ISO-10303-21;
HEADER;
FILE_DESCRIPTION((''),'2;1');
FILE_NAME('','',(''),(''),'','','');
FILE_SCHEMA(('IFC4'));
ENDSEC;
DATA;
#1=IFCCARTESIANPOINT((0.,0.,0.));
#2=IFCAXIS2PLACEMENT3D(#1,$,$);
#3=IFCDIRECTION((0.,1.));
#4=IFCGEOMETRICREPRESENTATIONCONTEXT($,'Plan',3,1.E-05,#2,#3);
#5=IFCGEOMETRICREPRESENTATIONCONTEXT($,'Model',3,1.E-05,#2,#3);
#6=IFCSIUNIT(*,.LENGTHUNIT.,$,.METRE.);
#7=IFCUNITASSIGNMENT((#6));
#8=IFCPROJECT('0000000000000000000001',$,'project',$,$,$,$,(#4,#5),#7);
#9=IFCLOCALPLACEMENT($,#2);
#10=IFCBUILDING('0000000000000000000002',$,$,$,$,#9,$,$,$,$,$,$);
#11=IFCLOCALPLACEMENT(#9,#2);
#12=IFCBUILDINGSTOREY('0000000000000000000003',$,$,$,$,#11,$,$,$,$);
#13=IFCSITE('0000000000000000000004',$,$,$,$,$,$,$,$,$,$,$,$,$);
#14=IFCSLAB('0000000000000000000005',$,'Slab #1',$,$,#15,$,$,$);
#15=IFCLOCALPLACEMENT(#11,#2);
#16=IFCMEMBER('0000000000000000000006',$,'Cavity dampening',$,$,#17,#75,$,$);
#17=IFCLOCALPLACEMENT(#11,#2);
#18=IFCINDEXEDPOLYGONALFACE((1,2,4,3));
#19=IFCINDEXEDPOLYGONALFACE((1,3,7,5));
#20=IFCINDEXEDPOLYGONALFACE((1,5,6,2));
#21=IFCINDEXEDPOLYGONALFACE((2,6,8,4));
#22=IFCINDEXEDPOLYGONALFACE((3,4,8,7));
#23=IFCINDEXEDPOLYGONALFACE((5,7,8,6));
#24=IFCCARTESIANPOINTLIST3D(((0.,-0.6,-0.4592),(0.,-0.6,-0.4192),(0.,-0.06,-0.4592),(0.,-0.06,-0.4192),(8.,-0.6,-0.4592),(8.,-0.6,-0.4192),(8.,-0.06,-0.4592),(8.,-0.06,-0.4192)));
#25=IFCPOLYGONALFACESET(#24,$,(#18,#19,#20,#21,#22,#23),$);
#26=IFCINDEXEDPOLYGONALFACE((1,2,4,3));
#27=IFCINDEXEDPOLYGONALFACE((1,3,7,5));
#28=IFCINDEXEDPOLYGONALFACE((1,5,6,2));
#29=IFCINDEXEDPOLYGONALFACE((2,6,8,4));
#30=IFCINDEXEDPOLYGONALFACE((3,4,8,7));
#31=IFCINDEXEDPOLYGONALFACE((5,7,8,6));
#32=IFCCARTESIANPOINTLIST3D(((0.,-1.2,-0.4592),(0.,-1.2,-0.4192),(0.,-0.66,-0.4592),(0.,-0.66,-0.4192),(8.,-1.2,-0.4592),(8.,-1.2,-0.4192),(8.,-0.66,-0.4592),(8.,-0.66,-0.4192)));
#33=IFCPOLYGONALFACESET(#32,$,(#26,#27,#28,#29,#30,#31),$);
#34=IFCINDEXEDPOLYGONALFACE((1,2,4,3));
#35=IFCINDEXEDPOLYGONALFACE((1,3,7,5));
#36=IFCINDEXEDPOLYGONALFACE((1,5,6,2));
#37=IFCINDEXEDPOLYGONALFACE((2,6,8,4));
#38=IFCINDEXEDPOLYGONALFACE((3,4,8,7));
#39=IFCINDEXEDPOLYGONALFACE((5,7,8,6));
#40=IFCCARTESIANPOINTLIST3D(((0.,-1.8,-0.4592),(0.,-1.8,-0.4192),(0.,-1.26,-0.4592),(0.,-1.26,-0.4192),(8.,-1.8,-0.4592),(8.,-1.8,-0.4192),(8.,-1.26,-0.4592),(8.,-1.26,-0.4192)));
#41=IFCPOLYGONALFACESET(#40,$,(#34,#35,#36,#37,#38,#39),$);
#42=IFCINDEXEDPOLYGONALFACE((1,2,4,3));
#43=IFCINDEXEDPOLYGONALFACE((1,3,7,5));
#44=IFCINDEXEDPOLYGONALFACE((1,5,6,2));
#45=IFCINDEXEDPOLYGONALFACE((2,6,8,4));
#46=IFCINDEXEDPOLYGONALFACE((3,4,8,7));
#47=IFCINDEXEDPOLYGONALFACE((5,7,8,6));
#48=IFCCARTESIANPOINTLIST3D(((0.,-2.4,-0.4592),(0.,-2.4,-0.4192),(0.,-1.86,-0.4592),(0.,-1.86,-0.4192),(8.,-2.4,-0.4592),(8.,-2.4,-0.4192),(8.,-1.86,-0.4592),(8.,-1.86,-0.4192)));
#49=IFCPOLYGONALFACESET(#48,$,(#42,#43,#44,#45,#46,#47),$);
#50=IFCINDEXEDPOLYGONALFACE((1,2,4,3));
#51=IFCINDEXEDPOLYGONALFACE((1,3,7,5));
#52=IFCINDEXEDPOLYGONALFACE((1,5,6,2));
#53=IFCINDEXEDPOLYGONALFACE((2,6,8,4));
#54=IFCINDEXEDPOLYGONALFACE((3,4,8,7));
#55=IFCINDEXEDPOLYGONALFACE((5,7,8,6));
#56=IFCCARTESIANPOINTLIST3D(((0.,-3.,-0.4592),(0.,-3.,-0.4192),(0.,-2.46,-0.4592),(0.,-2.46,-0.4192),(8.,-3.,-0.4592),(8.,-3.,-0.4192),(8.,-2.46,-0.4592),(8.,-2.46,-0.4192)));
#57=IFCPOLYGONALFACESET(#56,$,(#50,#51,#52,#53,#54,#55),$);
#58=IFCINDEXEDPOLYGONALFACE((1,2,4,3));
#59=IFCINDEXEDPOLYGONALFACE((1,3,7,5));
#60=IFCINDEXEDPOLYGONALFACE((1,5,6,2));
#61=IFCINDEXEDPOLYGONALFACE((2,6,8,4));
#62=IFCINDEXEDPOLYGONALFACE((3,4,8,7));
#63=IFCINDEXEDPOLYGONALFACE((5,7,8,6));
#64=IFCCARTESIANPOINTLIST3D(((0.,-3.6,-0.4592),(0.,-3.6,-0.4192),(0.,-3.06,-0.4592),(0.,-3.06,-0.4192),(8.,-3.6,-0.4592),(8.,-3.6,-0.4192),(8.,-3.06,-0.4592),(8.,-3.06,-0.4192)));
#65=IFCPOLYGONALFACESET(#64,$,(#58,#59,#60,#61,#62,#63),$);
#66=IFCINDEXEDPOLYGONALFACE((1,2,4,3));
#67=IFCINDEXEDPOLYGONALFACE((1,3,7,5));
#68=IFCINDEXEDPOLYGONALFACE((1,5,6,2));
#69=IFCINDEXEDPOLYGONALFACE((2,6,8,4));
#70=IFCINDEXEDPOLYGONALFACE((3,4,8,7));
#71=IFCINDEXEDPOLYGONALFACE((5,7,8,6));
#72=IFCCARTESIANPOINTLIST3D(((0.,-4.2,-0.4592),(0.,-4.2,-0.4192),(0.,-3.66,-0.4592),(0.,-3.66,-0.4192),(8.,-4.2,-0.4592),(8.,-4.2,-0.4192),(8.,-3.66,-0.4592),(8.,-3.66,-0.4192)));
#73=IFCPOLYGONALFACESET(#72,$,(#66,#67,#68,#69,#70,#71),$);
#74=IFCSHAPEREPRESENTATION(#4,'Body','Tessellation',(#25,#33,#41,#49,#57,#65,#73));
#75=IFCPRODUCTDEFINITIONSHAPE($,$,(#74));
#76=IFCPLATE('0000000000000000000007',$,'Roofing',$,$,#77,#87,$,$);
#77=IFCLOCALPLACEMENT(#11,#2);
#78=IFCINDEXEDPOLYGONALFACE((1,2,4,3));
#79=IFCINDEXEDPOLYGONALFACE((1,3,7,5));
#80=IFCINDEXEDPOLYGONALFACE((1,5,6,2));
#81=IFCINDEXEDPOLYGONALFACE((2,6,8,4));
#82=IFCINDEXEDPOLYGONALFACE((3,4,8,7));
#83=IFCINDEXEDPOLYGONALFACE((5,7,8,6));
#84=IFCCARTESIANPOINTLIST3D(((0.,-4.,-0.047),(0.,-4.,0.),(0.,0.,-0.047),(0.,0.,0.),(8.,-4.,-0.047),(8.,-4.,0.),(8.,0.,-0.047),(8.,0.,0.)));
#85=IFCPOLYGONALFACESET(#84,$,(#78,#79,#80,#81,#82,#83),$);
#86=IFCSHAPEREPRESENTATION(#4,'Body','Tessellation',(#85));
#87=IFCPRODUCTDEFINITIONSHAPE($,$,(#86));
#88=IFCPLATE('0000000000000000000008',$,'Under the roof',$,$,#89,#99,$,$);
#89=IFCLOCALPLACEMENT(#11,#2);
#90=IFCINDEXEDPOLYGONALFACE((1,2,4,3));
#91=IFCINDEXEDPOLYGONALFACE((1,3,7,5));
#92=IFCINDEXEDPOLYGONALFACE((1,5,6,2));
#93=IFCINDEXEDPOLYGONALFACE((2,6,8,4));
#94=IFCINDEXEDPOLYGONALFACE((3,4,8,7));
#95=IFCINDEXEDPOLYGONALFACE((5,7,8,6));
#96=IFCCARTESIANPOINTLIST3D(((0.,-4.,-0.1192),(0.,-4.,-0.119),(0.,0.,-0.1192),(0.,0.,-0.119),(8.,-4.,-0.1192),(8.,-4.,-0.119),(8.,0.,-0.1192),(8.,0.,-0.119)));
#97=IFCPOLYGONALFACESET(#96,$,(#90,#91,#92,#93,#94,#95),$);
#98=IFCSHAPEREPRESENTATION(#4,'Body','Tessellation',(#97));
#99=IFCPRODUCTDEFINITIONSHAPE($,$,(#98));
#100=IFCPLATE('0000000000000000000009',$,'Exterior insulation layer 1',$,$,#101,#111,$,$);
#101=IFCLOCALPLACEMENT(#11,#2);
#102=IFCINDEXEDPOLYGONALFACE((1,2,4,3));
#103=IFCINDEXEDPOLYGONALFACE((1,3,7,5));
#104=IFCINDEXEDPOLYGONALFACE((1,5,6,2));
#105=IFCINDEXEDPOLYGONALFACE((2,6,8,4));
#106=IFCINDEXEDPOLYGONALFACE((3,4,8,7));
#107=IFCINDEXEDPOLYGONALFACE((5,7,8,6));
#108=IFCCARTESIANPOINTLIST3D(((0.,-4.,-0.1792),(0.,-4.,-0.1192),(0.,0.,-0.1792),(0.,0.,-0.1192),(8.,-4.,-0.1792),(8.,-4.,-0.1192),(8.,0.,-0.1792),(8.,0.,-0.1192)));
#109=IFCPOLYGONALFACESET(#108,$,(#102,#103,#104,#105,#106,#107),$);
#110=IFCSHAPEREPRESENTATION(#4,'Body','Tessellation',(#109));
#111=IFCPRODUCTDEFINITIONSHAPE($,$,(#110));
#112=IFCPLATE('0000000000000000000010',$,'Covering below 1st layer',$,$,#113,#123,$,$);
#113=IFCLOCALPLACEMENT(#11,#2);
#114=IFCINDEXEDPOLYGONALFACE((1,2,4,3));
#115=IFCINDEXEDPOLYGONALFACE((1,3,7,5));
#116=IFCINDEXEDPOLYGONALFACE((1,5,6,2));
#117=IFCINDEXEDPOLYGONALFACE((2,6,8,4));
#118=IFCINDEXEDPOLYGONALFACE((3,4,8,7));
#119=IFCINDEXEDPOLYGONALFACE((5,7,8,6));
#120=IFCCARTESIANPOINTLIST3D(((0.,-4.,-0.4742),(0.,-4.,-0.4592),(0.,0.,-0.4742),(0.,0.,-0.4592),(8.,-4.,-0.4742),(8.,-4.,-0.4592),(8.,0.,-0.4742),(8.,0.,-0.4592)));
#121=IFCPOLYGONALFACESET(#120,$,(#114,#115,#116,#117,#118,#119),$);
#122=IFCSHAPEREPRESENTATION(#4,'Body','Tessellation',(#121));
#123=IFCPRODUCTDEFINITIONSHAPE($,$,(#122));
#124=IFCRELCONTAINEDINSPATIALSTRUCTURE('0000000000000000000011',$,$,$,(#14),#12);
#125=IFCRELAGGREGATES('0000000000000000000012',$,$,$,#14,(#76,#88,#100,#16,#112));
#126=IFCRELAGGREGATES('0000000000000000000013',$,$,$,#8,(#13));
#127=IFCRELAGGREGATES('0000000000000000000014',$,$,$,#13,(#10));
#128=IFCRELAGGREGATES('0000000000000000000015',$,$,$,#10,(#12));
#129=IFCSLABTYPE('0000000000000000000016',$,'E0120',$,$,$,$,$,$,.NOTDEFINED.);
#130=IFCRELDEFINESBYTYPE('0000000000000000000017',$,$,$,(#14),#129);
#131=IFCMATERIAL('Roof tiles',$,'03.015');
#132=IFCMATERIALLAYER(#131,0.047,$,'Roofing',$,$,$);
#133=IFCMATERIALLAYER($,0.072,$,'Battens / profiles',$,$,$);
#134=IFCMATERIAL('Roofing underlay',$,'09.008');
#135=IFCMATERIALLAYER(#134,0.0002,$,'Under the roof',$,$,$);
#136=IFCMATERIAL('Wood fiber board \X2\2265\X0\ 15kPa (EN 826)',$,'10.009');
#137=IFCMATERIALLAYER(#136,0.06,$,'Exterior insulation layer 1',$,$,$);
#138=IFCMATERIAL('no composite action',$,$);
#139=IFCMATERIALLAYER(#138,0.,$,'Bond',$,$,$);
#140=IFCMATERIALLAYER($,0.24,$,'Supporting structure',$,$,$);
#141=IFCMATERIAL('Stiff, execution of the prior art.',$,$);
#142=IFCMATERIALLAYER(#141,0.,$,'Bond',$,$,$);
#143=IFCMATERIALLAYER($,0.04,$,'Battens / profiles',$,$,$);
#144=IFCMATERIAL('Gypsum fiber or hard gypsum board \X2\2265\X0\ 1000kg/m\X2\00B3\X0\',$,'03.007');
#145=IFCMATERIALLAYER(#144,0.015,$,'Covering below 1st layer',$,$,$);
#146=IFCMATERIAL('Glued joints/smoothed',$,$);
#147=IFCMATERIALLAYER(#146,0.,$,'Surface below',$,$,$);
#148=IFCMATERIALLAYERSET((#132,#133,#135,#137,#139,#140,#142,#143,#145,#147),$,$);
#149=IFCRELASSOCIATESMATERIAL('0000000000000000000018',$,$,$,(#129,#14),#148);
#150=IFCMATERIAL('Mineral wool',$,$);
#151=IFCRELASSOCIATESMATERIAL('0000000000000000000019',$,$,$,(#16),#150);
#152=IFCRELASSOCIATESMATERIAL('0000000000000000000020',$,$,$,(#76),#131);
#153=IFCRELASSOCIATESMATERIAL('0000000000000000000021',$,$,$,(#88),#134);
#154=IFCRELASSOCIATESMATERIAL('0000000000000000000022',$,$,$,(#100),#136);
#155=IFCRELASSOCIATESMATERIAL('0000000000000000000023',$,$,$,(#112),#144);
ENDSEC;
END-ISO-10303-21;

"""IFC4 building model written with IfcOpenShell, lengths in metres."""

from ifc_helpers import new_model, si_unit, direction, frame, frame_2d, origin, origin_with_axes, place, context, project, spatial, rectangle, extrude, material, layer, layer_set, type_object, element, aggregate, save


model = new_model("IFC4")

# Units and contexts
plan_context = context("Plan", 3, precision=1e-05, world=origin(), true_north=direction((0.0, 1.0)))
model_context = context("Model", 3, precision=1e-05, world=origin(), true_north=direction((0.0, 1.0)))
ifc_project = project(units=[si_unit("LENGTHUNIT", "METRE")], contexts=[plan_context, model_context])

# Site, building, storey
site = spatial("IfcSite", under=ifc_project)
building_placement = place(None, origin())
building = spatial("IfcBuilding", under=site, at=building_placement)
storey_placement = place(building_placement, origin())
storey = spatial("IfcBuildingStorey", under=building, at=storey_placement)

# Slab, member, plates
ifc_material_1 = material(Name="Roof tiles", Category="03.015")
ifc_layer_1 = layer(ifc_material_1, 0.047, Name="Roofing")
ifc_layer_2 = layer(None, 0.072, Name="Battens / profiles")
ifc_material_2 = material(Name="Roofing underlay", Category="09.008")
ifc_layer_3 = layer(ifc_material_2, 0.0002, Name="Under the roof")
ifc_material_3 = material(Name="Wood fiber board ≥ 15kPa (EN 826)", Category="10.009")
ifc_layer_4 = layer(ifc_material_3, 0.06, Name="Exterior insulation layer 1")
ifc_material_4 = material(Name="no composite action")
ifc_layer_5 = layer(ifc_material_4, 0.0, Name="Bond")
ifc_layer_6 = layer(None, 0.24, Name="Supporting structure")
ifc_material_5 = material(Name="Stiff, execution of the prior art.")
ifc_layer_7 = layer(ifc_material_5, 0.0, Name="Bond")
ifc_layer_8 = layer(None, 0.04, Name="Battens / profiles")
ifc_material_6 = material(Name="Gypsum fiber or hard gypsum board ≥ 1000kg/m³", Category="03.007")
ifc_layer_9 = layer(ifc_material_6, 0.015, Name="Covering below 1st layer")
ifc_material_7 = material(Name="Glued joints/smoothed")
ifc_layer_10 = layer(ifc_material_7, 0.0, Name="Surface below")
ifc_layer_set = layer_set([ifc_layer_1, ifc_layer_2, ifc_layer_3, ifc_layer_4, ifc_layer_5, ifc_layer_6, ifc_layer_7, ifc_layer_8, ifc_layer_9, ifc_layer_10])
slab_type = type_object("IfcSlabType", Name="E0120", PredefinedType="NOTDEFINED", material=ifc_layer_set)
slab_placement = place(None, frame((0.0, 0.0, 0.0), z_axis=(0.0, 0.0, -1.0), x_axis=(1.0, 0.0, 0.0)))
slab = element("IfcSlab", 1, at=slab_placement, inside=storey, type_object=slab_type, material=ifc_layer_set, Name="Slab #1")
ifc_material_8 = material(Name="Mineral wool")
member_1_placement = place(slab_placement, origin())
member_1 = element("IfcMember", 2, at=member_1_placement, material=ifc_material_8, Name="Cavity dampening", context=plan_context, shape_type="SweptSolid", body=[
    extrude(rectangle(XDim=0.54, YDim=0.04, at=frame_2d((0.27, 0.02), x_axis=(1.0, 0.0))), frame((0.0, 0.06, 0.4192), z_axis=(1.0, 0.0, 0.0), x_axis=(0.0, 1.0, 0.0)), (0.0, 0.0, 1.0), 8.0),
    extrude(rectangle(XDim=0.54, YDim=0.04, at=frame_2d((0.27, 0.02), x_axis=(1.0, 0.0))), frame((0.0, 0.66, 0.4192), z_axis=(1.0, 0.0, 0.0), x_axis=(0.0, 1.0, 0.0)), (0.0, 0.0, 1.0), 8.0),
    extrude(rectangle(XDim=0.54, YDim=0.04, at=frame_2d((0.27, 0.02), x_axis=(1.0, 0.0))), frame((0.0, 1.26, 0.4192), z_axis=(1.0, 0.0, 0.0), x_axis=(0.0, 1.0, 0.0)), (0.0, 0.0, 1.0), 8.0),
    extrude(rectangle(XDim=0.54, YDim=0.04, at=frame_2d((0.27, 0.02), x_axis=(1.0, 0.0))), frame((0.0, 1.86, 0.4192), z_axis=(1.0, 0.0, 0.0), x_axis=(0.0, 1.0, 0.0)), (0.0, 0.0, 1.0), 8.0),
    extrude(rectangle(XDim=0.54, YDim=0.04, at=frame_2d((0.27, 0.02), x_axis=(1.0, 0.0))), frame((0.0, 2.46, 0.4192), z_axis=(1.0, 0.0, 0.0), x_axis=(0.0, 1.0, 0.0)), (0.0, 0.0, 1.0), 8.0),
    extrude(rectangle(XDim=0.54, YDim=0.04, at=frame_2d((0.27, 0.02), x_axis=(1.0, 0.0))), frame((0.0, 3.06, 0.4192), z_axis=(1.0, 0.0, 0.0), x_axis=(0.0, 1.0, 0.0)), (0.0, 0.0, 1.0), 8.0),
    extrude(rectangle(XDim=0.54, YDim=0.04, at=frame_2d((0.27, 0.02), x_axis=(1.0, 0.0))), frame((0.0, 3.66, 0.4192), z_axis=(1.0, 0.0, 0.0), x_axis=(0.0, 1.0, 0.0)), (0.0, 0.0, 1.0), 8.0),
])
plate_1_placement = place(slab_placement, origin())
plate_1 = element("IfcPlate", 3, at=plate_1_placement, material=ifc_material_1, Name="Roofing", context=plan_context, shape_type="SweptSolid", body=[
    extrude(rectangle(XDim=8.0, YDim=4.0, at=frame_2d((4.0, 2.0), x_axis=(1.0, 0.0))), origin_with_axes(), (0.0, 0.0, 1.0), 0.047),
])
plate_2_placement = place(slab_placement, origin())
plate_2 = element("IfcPlate", 4, at=plate_2_placement, material=ifc_material_2, Name="Under the roof", context=plan_context, shape_type="SweptSolid", body=[
    extrude(rectangle(XDim=8.0, YDim=4.0, at=frame_2d((4.0, 2.0), x_axis=(1.0, 0.0))), frame((0.0, 0.0, 0.119), z_axis=(0.0, 0.0, 1.0), x_axis=(1.0, 0.0, 0.0)), (0.0, 0.0, 1.0), 0.0002),
])
plate_3_placement = place(slab_placement, origin())
plate_3 = element("IfcPlate", 5, at=plate_3_placement, material=ifc_material_3, Name="Exterior insulation layer 1", context=plan_context, shape_type="SweptSolid", body=[
    extrude(rectangle(XDim=8.0, YDim=4.0, at=frame_2d((4.0, 2.0), x_axis=(1.0, 0.0))), frame((0.0, 0.0, 0.1192), z_axis=(0.0, 0.0, 1.0), x_axis=(1.0, 0.0, 0.0)), (0.0, 0.0, 1.0), 0.06),
])
plate_4_placement = place(slab_placement, origin())
plate_4 = element("IfcPlate", 6, at=plate_4_placement, material=ifc_material_6, Name="Covering below 1st layer", context=plan_context, shape_type="SweptSolid", body=[
    extrude(rectangle(XDim=8.0, YDim=4.0, at=frame_2d((4.0, 2.0), x_axis=(1.0, 0.0))), frame((0.0, 0.0, 0.4592), z_axis=(0.0, 0.0, 1.0), x_axis=(1.0, 0.0, 0.0)), (0.0, 0.0, 1.0), 0.015),
])
aggregate(slab, [plate_1, plate_2, plate_3, member_1, plate_4])

save(model, "model.ifc")
